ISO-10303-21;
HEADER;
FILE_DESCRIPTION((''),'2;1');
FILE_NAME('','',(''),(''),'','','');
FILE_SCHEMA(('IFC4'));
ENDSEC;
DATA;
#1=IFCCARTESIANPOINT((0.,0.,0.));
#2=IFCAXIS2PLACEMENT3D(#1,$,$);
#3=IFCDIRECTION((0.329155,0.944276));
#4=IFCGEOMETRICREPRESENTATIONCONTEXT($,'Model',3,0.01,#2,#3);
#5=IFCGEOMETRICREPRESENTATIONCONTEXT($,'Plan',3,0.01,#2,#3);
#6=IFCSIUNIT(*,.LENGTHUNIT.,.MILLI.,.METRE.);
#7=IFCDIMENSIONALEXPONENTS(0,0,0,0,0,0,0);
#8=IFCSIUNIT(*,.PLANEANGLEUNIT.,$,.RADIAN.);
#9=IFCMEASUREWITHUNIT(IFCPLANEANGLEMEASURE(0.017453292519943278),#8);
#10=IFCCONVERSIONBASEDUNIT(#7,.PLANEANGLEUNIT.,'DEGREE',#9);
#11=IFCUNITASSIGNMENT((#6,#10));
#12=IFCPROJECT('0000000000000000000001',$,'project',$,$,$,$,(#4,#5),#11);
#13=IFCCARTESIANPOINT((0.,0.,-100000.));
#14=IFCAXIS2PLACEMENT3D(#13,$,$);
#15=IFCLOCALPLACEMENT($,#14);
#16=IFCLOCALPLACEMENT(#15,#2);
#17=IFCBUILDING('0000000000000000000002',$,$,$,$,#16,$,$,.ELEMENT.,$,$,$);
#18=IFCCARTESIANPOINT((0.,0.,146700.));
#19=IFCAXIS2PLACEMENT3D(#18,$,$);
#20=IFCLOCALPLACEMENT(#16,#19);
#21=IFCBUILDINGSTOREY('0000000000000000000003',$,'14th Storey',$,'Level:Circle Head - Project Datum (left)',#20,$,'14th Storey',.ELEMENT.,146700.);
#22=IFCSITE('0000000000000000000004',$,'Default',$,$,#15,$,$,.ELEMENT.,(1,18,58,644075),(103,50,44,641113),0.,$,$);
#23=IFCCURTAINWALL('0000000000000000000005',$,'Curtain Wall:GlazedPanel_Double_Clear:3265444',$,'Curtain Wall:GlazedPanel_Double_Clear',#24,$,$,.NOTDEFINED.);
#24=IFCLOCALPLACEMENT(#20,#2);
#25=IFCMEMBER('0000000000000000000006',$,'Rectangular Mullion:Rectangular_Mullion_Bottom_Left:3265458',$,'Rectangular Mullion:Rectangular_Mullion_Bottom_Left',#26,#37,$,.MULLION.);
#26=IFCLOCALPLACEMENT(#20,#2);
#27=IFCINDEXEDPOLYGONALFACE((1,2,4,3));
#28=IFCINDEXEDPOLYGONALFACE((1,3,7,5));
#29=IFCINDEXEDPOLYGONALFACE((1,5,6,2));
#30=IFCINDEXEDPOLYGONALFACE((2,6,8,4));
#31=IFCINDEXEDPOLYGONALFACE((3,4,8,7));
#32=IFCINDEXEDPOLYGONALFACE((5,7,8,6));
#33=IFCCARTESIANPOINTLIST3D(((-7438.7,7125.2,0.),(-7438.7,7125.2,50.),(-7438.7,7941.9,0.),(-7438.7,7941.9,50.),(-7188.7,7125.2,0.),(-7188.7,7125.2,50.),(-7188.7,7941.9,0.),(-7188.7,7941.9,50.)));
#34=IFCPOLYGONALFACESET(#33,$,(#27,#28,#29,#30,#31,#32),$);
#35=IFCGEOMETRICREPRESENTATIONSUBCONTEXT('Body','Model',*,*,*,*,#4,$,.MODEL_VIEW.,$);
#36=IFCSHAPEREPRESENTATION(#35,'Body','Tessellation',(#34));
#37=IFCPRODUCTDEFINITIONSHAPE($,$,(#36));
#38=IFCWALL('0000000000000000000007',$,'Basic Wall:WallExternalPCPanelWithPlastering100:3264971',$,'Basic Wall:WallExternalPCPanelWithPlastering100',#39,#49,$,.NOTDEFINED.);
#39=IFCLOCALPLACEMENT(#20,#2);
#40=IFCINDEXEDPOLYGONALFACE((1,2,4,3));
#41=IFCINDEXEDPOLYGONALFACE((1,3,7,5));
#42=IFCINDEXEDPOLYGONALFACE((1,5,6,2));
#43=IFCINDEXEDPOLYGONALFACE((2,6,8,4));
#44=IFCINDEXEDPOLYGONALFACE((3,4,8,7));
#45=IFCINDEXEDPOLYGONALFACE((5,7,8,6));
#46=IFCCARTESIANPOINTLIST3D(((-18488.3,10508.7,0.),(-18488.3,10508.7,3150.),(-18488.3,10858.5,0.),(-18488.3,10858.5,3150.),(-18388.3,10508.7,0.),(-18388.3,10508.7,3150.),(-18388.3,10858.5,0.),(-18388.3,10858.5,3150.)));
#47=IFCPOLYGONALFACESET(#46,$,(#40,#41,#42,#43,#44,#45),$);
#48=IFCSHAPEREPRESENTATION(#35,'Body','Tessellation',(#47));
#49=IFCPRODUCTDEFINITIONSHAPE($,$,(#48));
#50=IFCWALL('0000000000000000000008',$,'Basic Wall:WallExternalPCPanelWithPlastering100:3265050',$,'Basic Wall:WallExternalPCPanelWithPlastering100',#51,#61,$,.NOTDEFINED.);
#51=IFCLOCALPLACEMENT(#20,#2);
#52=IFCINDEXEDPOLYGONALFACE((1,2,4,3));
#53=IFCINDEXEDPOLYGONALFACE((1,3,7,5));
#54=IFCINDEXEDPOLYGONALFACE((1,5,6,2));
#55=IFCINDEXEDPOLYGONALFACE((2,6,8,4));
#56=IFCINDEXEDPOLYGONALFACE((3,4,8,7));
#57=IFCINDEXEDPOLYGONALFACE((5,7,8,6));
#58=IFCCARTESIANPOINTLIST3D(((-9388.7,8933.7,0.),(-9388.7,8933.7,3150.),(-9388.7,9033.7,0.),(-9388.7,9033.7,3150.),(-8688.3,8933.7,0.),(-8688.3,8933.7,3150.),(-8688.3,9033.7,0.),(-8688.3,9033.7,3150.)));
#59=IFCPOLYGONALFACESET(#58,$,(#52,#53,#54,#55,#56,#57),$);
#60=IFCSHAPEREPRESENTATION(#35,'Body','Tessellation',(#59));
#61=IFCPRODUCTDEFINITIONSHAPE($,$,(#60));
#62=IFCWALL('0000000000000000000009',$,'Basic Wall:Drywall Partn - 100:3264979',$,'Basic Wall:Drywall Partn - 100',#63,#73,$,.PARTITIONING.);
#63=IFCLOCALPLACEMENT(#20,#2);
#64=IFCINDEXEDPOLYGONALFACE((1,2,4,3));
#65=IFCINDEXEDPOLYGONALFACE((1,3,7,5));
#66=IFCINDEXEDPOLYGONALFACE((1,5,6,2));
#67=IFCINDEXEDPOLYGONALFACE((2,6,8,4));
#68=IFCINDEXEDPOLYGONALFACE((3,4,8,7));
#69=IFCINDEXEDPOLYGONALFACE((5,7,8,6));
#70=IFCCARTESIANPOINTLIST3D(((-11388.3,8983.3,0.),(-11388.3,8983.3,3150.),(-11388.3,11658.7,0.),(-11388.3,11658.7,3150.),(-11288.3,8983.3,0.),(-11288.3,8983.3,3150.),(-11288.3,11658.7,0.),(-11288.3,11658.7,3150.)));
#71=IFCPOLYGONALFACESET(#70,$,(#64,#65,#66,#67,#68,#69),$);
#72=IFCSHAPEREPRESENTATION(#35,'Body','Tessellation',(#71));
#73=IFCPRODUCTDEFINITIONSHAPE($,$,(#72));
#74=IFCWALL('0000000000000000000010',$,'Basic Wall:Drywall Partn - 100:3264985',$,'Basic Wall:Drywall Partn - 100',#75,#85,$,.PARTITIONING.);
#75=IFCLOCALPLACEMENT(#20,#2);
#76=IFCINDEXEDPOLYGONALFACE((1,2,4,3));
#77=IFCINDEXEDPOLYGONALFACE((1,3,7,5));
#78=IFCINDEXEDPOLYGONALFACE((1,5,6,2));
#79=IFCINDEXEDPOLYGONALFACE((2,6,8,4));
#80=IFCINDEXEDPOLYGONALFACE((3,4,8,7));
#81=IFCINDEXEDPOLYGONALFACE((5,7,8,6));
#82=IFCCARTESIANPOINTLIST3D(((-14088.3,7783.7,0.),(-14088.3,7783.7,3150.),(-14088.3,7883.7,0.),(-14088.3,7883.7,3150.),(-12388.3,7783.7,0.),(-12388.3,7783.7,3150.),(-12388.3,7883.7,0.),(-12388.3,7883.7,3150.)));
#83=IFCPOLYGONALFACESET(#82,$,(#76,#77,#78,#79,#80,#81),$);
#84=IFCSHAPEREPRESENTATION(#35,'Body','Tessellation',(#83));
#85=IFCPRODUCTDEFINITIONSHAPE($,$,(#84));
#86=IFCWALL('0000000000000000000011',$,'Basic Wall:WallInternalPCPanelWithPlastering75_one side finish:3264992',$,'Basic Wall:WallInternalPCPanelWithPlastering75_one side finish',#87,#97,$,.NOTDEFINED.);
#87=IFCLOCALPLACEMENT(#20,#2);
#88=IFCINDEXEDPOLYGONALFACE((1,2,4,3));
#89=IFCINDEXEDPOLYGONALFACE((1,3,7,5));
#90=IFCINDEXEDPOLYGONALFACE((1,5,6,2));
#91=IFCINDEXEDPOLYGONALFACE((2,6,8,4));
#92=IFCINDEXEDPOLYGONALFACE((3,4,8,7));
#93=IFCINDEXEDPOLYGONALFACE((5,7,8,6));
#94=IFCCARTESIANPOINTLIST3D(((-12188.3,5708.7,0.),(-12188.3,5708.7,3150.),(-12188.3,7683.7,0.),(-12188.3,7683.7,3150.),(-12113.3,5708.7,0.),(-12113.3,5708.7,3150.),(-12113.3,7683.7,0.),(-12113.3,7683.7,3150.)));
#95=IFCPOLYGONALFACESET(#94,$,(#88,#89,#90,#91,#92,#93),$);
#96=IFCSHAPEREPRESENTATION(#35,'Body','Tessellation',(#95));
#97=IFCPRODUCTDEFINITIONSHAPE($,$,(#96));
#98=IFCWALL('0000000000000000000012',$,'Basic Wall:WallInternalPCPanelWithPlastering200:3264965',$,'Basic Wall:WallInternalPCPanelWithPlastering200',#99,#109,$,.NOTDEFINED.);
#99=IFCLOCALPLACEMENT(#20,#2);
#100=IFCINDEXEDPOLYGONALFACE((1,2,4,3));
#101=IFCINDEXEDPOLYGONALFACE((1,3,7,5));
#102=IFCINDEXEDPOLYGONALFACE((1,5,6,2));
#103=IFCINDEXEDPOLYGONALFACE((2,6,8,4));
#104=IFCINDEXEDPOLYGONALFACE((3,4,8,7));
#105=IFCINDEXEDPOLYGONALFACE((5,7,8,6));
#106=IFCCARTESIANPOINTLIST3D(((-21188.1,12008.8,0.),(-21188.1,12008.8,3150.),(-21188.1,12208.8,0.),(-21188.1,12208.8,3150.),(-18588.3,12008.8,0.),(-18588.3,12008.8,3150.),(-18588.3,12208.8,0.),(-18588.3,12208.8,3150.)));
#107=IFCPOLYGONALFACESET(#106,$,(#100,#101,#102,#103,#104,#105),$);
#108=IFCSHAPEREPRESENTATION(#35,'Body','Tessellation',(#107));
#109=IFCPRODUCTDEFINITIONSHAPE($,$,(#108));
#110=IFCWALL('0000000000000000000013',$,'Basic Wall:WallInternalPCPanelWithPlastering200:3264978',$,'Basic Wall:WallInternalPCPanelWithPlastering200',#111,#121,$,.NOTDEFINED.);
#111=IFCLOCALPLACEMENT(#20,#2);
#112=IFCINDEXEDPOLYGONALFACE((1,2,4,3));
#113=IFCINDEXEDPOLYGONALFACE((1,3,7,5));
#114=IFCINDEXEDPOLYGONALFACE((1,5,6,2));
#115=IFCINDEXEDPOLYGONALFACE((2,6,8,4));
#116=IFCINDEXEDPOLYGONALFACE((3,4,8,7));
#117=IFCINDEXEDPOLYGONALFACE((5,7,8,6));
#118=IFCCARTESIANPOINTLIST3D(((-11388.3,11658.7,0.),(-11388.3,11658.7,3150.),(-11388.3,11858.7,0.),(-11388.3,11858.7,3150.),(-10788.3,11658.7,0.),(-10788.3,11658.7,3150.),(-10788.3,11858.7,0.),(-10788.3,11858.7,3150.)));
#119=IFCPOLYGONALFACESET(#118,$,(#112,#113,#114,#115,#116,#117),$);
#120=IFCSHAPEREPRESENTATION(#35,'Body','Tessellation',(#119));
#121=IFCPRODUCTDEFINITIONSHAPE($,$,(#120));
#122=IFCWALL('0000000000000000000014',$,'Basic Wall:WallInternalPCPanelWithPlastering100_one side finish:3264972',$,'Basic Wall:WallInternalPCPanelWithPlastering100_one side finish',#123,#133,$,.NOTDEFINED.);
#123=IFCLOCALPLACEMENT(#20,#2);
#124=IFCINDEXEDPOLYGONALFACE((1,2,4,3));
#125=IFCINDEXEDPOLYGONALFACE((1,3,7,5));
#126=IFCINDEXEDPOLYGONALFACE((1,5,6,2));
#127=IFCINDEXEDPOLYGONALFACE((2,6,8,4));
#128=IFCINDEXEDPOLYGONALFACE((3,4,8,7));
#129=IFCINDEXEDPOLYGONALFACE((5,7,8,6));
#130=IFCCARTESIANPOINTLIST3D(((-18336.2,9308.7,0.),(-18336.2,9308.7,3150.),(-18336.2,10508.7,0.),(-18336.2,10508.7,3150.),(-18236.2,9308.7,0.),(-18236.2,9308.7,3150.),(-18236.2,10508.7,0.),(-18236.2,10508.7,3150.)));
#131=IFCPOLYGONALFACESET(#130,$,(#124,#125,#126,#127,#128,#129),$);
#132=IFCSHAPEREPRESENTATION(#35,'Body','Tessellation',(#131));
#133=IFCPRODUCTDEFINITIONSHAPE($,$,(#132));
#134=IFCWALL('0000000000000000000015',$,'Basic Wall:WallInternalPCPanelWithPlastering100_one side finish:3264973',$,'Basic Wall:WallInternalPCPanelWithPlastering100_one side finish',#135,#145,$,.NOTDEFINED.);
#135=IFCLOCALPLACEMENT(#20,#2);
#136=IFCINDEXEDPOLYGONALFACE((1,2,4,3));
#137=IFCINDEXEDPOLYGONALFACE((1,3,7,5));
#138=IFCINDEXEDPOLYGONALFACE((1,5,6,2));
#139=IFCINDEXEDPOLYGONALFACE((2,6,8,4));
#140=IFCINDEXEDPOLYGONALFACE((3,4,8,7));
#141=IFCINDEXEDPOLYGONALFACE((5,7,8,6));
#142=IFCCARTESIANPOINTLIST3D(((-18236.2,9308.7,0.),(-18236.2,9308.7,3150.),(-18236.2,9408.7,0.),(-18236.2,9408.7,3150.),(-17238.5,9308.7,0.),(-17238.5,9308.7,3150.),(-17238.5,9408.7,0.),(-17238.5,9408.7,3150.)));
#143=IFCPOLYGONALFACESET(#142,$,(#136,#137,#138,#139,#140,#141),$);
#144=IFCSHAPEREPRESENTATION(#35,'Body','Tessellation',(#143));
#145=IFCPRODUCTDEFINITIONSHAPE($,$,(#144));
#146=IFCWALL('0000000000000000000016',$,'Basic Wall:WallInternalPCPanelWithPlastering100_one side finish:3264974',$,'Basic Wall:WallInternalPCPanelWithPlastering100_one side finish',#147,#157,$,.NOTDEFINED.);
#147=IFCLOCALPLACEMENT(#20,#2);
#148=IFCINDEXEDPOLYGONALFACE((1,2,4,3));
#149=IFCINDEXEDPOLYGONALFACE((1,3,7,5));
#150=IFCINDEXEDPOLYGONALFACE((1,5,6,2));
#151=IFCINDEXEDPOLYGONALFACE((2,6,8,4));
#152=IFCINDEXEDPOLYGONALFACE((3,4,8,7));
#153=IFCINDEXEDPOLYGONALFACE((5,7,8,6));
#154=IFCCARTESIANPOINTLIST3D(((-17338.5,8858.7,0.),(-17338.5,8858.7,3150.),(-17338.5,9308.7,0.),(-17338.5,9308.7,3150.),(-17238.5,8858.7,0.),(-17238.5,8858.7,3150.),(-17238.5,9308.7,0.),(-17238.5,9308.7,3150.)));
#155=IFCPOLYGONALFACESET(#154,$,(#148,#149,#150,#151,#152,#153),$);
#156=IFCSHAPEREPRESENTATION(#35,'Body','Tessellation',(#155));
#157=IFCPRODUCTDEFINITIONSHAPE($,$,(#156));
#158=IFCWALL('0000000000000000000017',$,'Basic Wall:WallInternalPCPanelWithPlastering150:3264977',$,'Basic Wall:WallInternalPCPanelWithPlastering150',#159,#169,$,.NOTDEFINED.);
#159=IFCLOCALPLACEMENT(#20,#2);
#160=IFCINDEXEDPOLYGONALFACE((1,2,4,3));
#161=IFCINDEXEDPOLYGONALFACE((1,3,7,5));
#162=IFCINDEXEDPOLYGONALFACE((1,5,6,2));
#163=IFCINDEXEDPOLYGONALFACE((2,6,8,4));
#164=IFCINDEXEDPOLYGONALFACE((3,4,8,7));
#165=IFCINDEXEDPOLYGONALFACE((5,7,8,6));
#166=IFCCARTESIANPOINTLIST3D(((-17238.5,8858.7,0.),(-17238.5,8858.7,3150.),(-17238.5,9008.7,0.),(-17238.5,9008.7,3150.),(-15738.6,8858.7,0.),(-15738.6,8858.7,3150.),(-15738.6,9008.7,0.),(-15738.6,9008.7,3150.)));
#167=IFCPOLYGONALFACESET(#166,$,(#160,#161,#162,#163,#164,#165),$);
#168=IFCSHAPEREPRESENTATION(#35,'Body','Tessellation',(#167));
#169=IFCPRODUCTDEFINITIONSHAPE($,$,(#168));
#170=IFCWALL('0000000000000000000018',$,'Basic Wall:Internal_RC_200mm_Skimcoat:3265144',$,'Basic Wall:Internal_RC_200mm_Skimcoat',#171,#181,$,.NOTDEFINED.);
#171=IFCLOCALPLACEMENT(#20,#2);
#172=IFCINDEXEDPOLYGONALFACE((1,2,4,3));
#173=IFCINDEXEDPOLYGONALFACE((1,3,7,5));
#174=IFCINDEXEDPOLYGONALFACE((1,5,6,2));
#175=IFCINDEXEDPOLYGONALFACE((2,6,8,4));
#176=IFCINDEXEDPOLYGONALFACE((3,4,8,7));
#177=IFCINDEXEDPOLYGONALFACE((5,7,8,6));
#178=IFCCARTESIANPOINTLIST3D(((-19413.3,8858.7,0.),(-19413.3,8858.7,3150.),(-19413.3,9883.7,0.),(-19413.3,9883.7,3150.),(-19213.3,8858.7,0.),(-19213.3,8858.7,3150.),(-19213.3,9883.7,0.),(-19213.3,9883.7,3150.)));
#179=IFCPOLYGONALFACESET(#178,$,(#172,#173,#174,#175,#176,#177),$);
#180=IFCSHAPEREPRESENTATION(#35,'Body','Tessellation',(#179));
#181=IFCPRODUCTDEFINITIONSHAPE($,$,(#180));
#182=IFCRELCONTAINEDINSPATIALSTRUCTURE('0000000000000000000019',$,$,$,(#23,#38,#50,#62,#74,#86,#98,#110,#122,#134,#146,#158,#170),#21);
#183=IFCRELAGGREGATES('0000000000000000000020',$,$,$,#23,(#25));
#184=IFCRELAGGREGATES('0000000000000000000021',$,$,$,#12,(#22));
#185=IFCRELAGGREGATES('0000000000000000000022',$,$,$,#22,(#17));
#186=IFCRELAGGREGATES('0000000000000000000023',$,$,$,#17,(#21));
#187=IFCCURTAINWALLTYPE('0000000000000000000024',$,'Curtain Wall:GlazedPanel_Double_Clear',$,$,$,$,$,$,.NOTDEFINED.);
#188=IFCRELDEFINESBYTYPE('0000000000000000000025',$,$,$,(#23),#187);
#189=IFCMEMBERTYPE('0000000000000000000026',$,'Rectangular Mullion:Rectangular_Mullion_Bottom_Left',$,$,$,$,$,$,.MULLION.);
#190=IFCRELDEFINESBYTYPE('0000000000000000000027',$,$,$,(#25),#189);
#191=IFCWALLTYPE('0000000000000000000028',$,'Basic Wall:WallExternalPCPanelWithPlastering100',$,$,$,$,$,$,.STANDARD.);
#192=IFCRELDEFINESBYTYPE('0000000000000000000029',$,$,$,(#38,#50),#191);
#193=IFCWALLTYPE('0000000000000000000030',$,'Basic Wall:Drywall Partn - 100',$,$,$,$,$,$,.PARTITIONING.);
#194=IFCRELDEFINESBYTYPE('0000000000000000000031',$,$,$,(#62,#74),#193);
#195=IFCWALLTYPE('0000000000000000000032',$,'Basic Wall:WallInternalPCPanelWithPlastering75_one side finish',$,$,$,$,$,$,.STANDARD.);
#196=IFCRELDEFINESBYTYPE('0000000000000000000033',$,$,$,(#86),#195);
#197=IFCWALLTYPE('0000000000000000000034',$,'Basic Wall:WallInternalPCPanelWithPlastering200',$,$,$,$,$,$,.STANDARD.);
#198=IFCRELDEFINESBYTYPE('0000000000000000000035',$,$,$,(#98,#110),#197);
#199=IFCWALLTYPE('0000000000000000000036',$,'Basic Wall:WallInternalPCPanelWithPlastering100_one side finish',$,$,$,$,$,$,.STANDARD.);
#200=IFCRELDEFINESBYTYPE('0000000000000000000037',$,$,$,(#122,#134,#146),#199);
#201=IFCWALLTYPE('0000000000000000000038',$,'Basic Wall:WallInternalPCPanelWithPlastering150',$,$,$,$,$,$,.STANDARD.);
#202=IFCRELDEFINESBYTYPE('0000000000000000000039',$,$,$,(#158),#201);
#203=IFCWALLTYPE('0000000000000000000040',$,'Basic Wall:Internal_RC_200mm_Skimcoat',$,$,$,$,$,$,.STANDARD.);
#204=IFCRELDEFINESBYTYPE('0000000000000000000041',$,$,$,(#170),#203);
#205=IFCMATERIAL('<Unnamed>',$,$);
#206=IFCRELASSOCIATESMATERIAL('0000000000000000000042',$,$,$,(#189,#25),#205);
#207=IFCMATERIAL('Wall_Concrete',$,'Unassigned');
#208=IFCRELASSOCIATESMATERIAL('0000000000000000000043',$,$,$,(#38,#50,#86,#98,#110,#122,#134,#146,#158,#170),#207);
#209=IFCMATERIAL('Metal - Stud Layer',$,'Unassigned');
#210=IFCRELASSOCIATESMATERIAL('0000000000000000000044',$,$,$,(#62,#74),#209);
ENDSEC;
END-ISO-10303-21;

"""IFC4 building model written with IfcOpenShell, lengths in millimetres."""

from ifc_helpers import new_model, entity, si_unit, converted_unit, direction, frame, origin, place, context, subcontext, project, spatial, indexed_curve, outline, extrude, source, transform, mapped, material, type_object, type_shapes, element, aggregate, save


model = new_model("IFC4")

# Units and contexts
model_context = context("Model", 3, precision=0.01, world=origin(), true_north=direction((0.329155, 0.944276)))
plan_context = context("Plan", 3, precision=0.01, world=origin(), true_north=direction((0.329155, 0.944276)))
body_context = subcontext(model_context, "Body", "Model", "MODEL_VIEW")
ifc_project = project(units=[si_unit("LENGTHUNIT", "METRE", prefix="MILLI"), converted_unit("PLANEANGLEUNIT", "DEGREE", entity("IfcPlaneAngleMeasure", 0.017453292519943278), si_unit("PLANEANGLEUNIT", "RADIAN"), dimensions=[0, 0, 0, 0, 0, 0, 0])], contexts=[model_context, plan_context])

# Site, building, storey
site_placement = place(None, frame((0.0, 0.0, -100000.0)))
site = spatial("IfcSite", under=ifc_project, at=site_placement, Name="Default", CompositionType="ELEMENT", RefLatitude=(1, 18, 58, 644075), RefLongitude=(103, 50, 44, 641113), RefElevation=0.0)
building_placement = place(site_placement, origin())
building = spatial("IfcBuilding", under=site, at=building_placement, CompositionType="ELEMENT")
storey_placement = place(building_placement, frame((0.0, 0.0, 146700.0)))
storey = spatial("IfcBuildingStorey", under=building, at=storey_placement, Name="14th Storey", ObjectType="Level:Circle Head - Project Datum (left)", LongName="14th Storey", CompositionType="ELEMENT", Elevation=146700.0)

# Shared definitions
curtain_wall_type = type_object("IfcCurtainWallType", Name="Curtain Wall:GlazedPanel_Double_Clear", PredefinedType="NOTDEFINED")
ifc_material_1 = material(Name="<Unnamed>")

# Curtain wall
curtain_wall_1_placement = place(storey_placement, frame((0.0, 0.0, -146700.0)))
curtain_wall_1 = element("IfcCurtainWall", 1, at=curtain_wall_1_placement, inside=storey, type_object=curtain_wall_type, Name="Curtain Wall:GlazedPanel_Double_Clear:3265444", ObjectType="Curtain Wall:GlazedPanel_Double_Clear", PredefinedType="NOTDEFINED")

# Member
member_type_1 = type_object("IfcMemberType", Name="Rectangular Mullion:Rectangular_Mullion_Bottom_Left", PredefinedType="MULLION", material=ifc_material_1)
shared_shape_1 = source(origin(), body_context, "Body", "SweptSolid", [
    extrude(outline(indexed_curve([(-25.0, -125.0), (25.0, -125.0), (25.0, 125.0), (-25.0, 125.0), (-25.0, -125.0)], self_intersect=False)), frame((-25.0, 0.0, -816.7), z_axis=(0.0, 0.0, 1.0), x_axis=(-1.0, 0.0, 0.0)), (0.0, 0.0, 1.0), 816.7),
])
type_shapes(member_type_1, [shared_shape_1])
member_1_placement = place(curtain_wall_1_placement, frame((-7313.7, 7941.9, 146700.0), z_axis=(0.0, 1.0, 0.0), x_axis=(0.0, 0.0, -1.0)))
member_1 = element("IfcMember", 2, at=member_1_placement, type_object=member_type_1, material=ifc_material_1, Name="Rectangular Mullion:Rectangular_Mullion_Bottom_Left:3265458", ObjectType="Rectangular Mullion:Rectangular_Mullion_Bottom_Left", PredefinedType="MULLION", context=body_context, shape_type="MappedRepresentation", body=[
    mapped(shared_shape_1, transform((0.0, 0.0, 0.0), scale=1.0)),
])
aggregate(curtain_wall_1, [member_1])

# Walls
ifc_material_2 = material(Name="Wall_Concrete", Category="Unassigned")
wall_type_1 = type_object("IfcWallType", Name="Basic Wall:WallExternalPCPanelWithPlastering100", PredefinedType="STANDARD")
wall_1_placement = place(storey_placement, frame((-18438.3, 10858.5, 0.0), z_axis=(0.0, 0.0, 1.0), x_axis=(0.0, -1.0, 0.0)))
element("IfcWall", 3, at=wall_1_placement, inside=storey, type_object=wall_type_1, material=ifc_material_2, Name="Basic Wall:WallExternalPCPanelWithPlastering100:3264971", ObjectType="Basic Wall:WallExternalPCPanelWithPlastering100", PredefinedType="NOTDEFINED", context=body_context, shape_type="SweptSolid", body=[
    extrude(outline(indexed_curve([(349.8, 50.0), (0.0, 50.0), (0.0, -50.0), (349.8, -50.0), (349.8, 50.0)], self_intersect=False)), origin(), (0.0, 0.0, 1.0), 3150.0),
])
wall_2_placement = place(storey_placement, frame((-8688.3, 8983.7, 0.0), z_axis=(0.0, 0.0, 1.0), x_axis=(-1.0, 0.0, 0.0)))
element("IfcWall", 4, at=wall_2_placement, inside=storey, type_object=wall_type_1, material=ifc_material_2, Name="Basic Wall:WallExternalPCPanelWithPlastering100:3265050", ObjectType="Basic Wall:WallExternalPCPanelWithPlastering100", PredefinedType="NOTDEFINED", context=body_context, shape_type="SweptSolid", body=[
    extrude(outline(indexed_curve([(700.4, 50.0), (0.0, 50.0), (0.0, -50.0), (700.4, -50.0), (700.4, 50.0)], self_intersect=False)), origin(), (0.0, 0.0, 1.0), 3150.0),
])
ifc_material_3 = material(Name="Metal - Stud Layer", Category="Unassigned")
wall_type_2 = type_object("IfcWallType", Name="Basic Wall:Drywall Partn - 100", PredefinedType="PARTITIONING")
wall_3_placement = place(storey_placement, frame((-11338.3, 11658.7, 0.0), z_axis=(0.0, 0.0, 1.0), x_axis=(0.0, -1.0, 0.0)))
element("IfcWall", 5, at=wall_3_placement, inside=storey, type_object=wall_type_2, material=ifc_material_3, Name="Basic Wall:Drywall Partn - 100:3264979", ObjectType="Basic Wall:Drywall Partn - 100", PredefinedType="PARTITIONING", context=body_context, shape_type="SweptSolid", body=[
    extrude(outline(indexed_curve([(2675.4, 50.0), (0.0, 50.0), (0.0, -50.0), (2675.4, -50.0), (2675.4, 50.0)], self_intersect=False)), origin(), (0.0, 0.0, 1.0), 3150.0),
])
wall_4_placement = place(storey_placement, frame((-12388.3, 7833.7, 0.0), z_axis=(0.0, 0.0, 1.0), x_axis=(-1.0, 0.0, 0.0)))
element("IfcWall", 6, at=wall_4_placement, inside=storey, type_object=wall_type_2, material=ifc_material_3, Name="Basic Wall:Drywall Partn - 100:3264985", ObjectType="Basic Wall:Drywall Partn - 100", PredefinedType="PARTITIONING", context=body_context, shape_type="SweptSolid", body=[
    extrude(outline(indexed_curve([(1700.0, 50.0), (0.0, 50.0), (0.0, -50.0), (1700.0, -50.0), (1700.0, 50.0)], self_intersect=False)), origin(), (0.0, 0.0, 1.0), 3150.0),
])
wall_type_3 = type_object("IfcWallType", Name="Basic Wall:WallInternalPCPanelWithPlastering75_one side finish", PredefinedType="STANDARD")
wall_5_placement = place(storey_placement, frame((-12150.8, 7683.7, 0.0), z_axis=(0.0, 0.0, 1.0), x_axis=(0.0, -1.0, 0.0)))
element("IfcWall", 7, at=wall_5_placement, inside=storey, type_object=wall_type_3, material=ifc_material_2, Name="Basic Wall:WallInternalPCPanelWithPlastering75_one side finish:3264992", ObjectType="Basic Wall:WallInternalPCPanelWithPlastering75_one side finish", PredefinedType="NOTDEFINED", context=body_context, shape_type="SweptSolid", body=[
    extrude(outline(indexed_curve([(1975.0, 37.5), (0.0, 37.5), (0.0, -37.5), (1975.0, -37.5), (1975.0, 37.5)], self_intersect=False)), origin(), (0.0, 0.0, 1.0), 3150.0),
])
wall_type_4 = type_object("IfcWallType", Name="Basic Wall:WallInternalPCPanelWithPlastering200", PredefinedType="STANDARD")
wall_6_placement = place(storey_placement, frame((-18588.3, 12108.8, 0.0), z_axis=(0.0, 0.0, 1.0), x_axis=(-1.0, 0.0, 0.0)))
element("IfcWall", 8, at=wall_6_placement, inside=storey, type_object=wall_type_4, material=ifc_material_2, Name="Basic Wall:WallInternalPCPanelWithPlastering200:3264965", ObjectType="Basic Wall:WallInternalPCPanelWithPlastering200", PredefinedType="NOTDEFINED", context=body_context, shape_type="SweptSolid", body=[
    extrude(outline(indexed_curve([(2599.8, 100.0), (0.0, 100.0), (0.0, -100.0), (2599.8, -100.0), (2599.8, 100.0)], self_intersect=False)), origin(), (0.0, 0.0, 1.0), 3150.0),
])
wall_7_placement = place(storey_placement, frame((-10788.3, 11758.7, 0.0), z_axis=(0.0, 0.0, 1.0), x_axis=(-1.0, 0.0, 0.0)))
element("IfcWall", 9, at=wall_7_placement, inside=storey, type_object=wall_type_4, material=ifc_material_2, Name="Basic Wall:WallInternalPCPanelWithPlastering200:3264978", ObjectType="Basic Wall:WallInternalPCPanelWithPlastering200", PredefinedType="NOTDEFINED", context=body_context, shape_type="SweptSolid", body=[
    extrude(outline(indexed_curve([(600.0, 100.0), (0.0, 100.0), (0.0, -100.0), (600.0, -100.0), (600.0, 100.0)], self_intersect=False)), origin(), (0.0, 0.0, 1.0), 3150.0),
])
wall_type_5 = type_object("IfcWallType", Name="Basic Wall:WallInternalPCPanelWithPlastering100_one side finish", PredefinedType="STANDARD")
wall_8_placement = place(storey_placement, frame((-18286.2, 9308.7, 0.0), z_axis=(0.0, 0.0, 1.0), x_axis=(0.0, 1.0, 0.0)))
element("IfcWall", 10, at=wall_8_placement, inside=storey, type_object=wall_type_5, material=ifc_material_2, Name="Basic Wall:WallInternalPCPanelWithPlastering100_one side finish:3264972", ObjectType="Basic Wall:WallInternalPCPanelWithPlastering100_one side finish", PredefinedType="NOTDEFINED", context=body_context, shape_type="SweptSolid", body=[
    extrude(outline(indexed_curve([(1200.0, 50.0), (0.0, 50.0), (0.0, -50.0), (1200.0, -50.0), (1200.0, 50.0)], self_intersect=False)), origin(), (0.0, 0.0, 1.0), 3150.0),
])
wall_9_placement = place(storey_placement, frame((-17238.5, 9358.7, 0.0), z_axis=(0.0, 0.0, 1.0), x_axis=(-1.0, 0.0, 0.0)))
element("IfcWall", 11, at=wall_9_placement, inside=storey, type_object=wall_type_5, material=ifc_material_2, Name="Basic Wall:WallInternalPCPanelWithPlastering100_one side finish:3264973", ObjectType="Basic Wall:WallInternalPCPanelWithPlastering100_one side finish", PredefinedType="NOTDEFINED", context=body_context, shape_type="SweptSolid", body=[
    extrude(outline(indexed_curve([(997.7, 50.0), (0.0, 50.0), (0.0, -50.0), (997.7, -50.0), (997.7, 50.0)], self_intersect=False)), origin(), (0.0, 0.0, 1.0), 3150.0),
])
wall_10_placement = place(storey_placement, frame((-17288.5, 8858.7, 0.0), z_axis=(0.0, 0.0, 1.0), x_axis=(0.0, 1.0, 0.0)))
element("IfcWall", 12, at=wall_10_placement, inside=storey, type_object=wall_type_5, material=ifc_material_2, Name="Basic Wall:WallInternalPCPanelWithPlastering100_one side finish:3264974", ObjectType="Basic Wall:WallInternalPCPanelWithPlastering100_one side finish", PredefinedType="NOTDEFINED", context=body_context, shape_type="SweptSolid", body=[
    extrude(outline(indexed_curve([(450.0, 50.0), (0.0, 50.0), (0.0, -50.0), (450.0, -50.0), (450.0, 50.0)], self_intersect=False)), origin(), (0.0, 0.0, 1.0), 3150.0),
])
wall_type_6 = type_object("IfcWallType", Name="Basic Wall:WallInternalPCPanelWithPlastering150", PredefinedType="STANDARD")
wall_11_placement = place(storey_placement, frame((-17238.5, 8933.7, 0.0)))
element("IfcWall", 13, at=wall_11_placement, inside=storey, type_object=wall_type_6, material=ifc_material_2, Name="Basic Wall:WallInternalPCPanelWithPlastering150:3264977", ObjectType="Basic Wall:WallInternalPCPanelWithPlastering150", PredefinedType="NOTDEFINED", context=body_context, shape_type="SweptSolid", body=[
    extrude(outline(indexed_curve([(1499.9, 75.0), (0.0, 75.0), (0.0, -75.0), (1499.9, -75.0), (1499.9, 75.0)], self_intersect=False)), origin(), (0.0, 0.0, 1.0), 3150.0),
])
wall_type_7 = type_object("IfcWallType", Name="Basic Wall:Internal_RC_200mm_Skimcoat", PredefinedType="STANDARD")
wall_12_placement = place(storey_placement, frame((-19313.3, 9883.7, 0.0), z_axis=(0.0, 0.0, 1.0), x_axis=(0.0, -1.0, 0.0)))
element("IfcWall", 14, at=wall_12_placement, inside=storey, type_object=wall_type_7, material=ifc_material_2, Name="Basic Wall:Internal_RC_200mm_Skimcoat:3265144", ObjectType="Basic Wall:Internal_RC_200mm_Skimcoat", PredefinedType="NOTDEFINED", context=body_context, shape_type="SweptSolid", body=[
    extrude(outline(indexed_curve([(1025.0, 100.0), (0.0, 100.0), (0.0, -100.0), (1025.0, -100.0), (1025.0, 100.0)], self_intersect=False)), origin(), (0.0, 0.0, 1.0), 3150.0),
])

save(model, "model.ifc")
